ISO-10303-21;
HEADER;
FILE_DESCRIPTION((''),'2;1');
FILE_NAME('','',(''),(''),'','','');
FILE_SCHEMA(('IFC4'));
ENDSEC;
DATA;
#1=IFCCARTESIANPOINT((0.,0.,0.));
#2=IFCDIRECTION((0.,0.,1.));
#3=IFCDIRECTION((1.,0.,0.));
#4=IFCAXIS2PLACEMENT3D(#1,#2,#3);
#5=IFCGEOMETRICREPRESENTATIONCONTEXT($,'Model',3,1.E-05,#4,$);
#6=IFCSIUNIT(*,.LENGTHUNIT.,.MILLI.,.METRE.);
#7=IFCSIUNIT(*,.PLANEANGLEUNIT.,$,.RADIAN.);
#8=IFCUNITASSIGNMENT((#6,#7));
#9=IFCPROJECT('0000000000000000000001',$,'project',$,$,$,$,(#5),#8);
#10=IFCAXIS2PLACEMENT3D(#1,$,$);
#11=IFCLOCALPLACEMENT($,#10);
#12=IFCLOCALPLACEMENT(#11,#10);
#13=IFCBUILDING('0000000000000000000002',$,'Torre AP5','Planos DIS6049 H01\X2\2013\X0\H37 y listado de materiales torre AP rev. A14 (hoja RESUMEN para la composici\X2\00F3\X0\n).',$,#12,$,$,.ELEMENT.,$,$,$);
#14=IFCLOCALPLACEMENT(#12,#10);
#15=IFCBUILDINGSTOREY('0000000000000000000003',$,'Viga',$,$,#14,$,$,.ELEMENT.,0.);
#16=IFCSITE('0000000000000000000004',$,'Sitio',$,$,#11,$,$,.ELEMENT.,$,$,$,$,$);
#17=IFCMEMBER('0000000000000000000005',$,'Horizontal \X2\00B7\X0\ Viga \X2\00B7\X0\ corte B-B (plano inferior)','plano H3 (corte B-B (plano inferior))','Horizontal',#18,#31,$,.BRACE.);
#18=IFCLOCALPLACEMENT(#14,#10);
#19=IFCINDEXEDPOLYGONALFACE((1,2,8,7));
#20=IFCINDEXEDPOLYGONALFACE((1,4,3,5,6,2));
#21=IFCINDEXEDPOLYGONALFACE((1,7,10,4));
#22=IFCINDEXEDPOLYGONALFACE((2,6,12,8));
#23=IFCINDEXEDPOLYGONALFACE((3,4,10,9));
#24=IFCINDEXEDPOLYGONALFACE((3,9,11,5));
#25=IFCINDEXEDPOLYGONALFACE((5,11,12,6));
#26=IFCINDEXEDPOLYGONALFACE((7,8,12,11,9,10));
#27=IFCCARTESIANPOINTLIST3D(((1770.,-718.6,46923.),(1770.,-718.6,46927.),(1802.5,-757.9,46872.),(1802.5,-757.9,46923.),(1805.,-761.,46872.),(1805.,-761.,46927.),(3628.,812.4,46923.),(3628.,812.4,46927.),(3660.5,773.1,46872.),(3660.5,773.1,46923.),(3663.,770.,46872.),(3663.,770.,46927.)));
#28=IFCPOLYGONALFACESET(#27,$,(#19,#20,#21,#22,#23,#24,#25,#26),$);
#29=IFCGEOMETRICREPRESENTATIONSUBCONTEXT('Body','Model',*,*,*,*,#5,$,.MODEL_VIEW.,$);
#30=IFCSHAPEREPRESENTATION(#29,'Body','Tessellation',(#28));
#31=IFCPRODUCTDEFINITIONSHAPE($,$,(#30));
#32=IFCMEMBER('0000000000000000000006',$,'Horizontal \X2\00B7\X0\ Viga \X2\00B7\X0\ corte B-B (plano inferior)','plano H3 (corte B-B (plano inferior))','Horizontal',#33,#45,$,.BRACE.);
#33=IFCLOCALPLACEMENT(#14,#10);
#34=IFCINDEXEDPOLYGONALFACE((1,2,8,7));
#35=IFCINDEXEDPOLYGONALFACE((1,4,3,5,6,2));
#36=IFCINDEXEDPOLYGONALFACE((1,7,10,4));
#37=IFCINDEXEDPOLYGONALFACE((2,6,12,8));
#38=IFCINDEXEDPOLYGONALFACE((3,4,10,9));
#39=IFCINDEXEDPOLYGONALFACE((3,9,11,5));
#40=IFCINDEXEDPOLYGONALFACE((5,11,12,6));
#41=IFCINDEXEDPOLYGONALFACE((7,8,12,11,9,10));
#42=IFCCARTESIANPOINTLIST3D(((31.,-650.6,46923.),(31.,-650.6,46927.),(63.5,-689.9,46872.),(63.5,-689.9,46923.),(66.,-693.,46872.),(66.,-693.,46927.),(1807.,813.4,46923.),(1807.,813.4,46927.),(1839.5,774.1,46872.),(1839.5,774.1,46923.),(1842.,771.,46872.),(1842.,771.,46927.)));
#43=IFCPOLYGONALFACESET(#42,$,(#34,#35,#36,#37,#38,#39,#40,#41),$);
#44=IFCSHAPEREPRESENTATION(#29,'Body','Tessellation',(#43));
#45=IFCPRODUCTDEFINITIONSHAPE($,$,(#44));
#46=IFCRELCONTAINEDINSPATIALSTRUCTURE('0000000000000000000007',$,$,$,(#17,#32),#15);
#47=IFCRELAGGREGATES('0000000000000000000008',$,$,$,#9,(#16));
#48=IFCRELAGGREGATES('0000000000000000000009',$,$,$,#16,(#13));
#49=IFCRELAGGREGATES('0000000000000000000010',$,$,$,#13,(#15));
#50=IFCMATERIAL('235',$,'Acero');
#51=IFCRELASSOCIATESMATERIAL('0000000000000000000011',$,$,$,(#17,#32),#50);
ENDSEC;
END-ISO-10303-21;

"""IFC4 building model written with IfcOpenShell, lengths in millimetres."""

from ifc_helpers import new_model, si_unit, frame, frame_2d, origin, origin_with_axes, place, context, subcontext, project, spatial, l_section, extrude, material, element, save


model = new_model("IFC4")

# Units and contexts
model_context = context("Model", 3, precision=1e-05, world=origin_with_axes())
body_context = subcontext(model_context, "Body", "Model", "MODEL_VIEW")
ifc_project = project(units=[si_unit("LENGTHUNIT", "METRE", prefix="MILLI"), si_unit("PLANEANGLEUNIT", "RADIAN")], contexts=[model_context])

# Site, building, storey
site_placement = place(None, origin())
site = spatial("IfcSite", under=ifc_project, at=site_placement, Name="Sitio", CompositionType="ELEMENT")
building_placement = place(site_placement, origin())
building = spatial("IfcBuilding", under=site, at=building_placement, Name="Torre AP5", Description="Planos DIS6049 H01–H37 y listado de materiales torre AP rev. A14 (hoja RESUMEN para la composición).", CompositionType="ELEMENT")
storey_placement = place(building_placement, origin())
storey = spatial("IfcBuildingStorey", under=building, at=storey_placement, Name="Viga", CompositionType="ELEMENT", Elevation=0.0)

# Members
ifc_material = material(Name="235", Category="Acero")
member_1_placement = place(storey_placement, frame((3663.0, 770.0, 46927.0), z_axis=(-0.77175, -0.635926, 0.0), x_axis=(-0.635926, 0.77175, 0.0)))
element("IfcMember", 1, at=member_1_placement, inside=storey, material=ifc_material, Name="Horizontal · Viga · corte B-B (plano inferior)", Description="plano H3 (corte B-B (plano inferior))", ObjectType="Horizontal", PredefinedType="BRACE", context=body_context, shape_type="SweptSolid", body=[
    extrude(l_section(Depth=55.0, Width=55.0, Thickness=4.0, at=frame_2d((27.5, 27.5))), None, (0.0, 0.0, 1.0), 2407.5),
])
member_2_placement = place(storey_placement, frame((1842.0, 771.0, 46927.0), z_axis=(-0.771629, -0.636073, 0.0), x_axis=(-0.636073, 0.771629, 0.0)))
element("IfcMember", 2, at=member_2_placement, inside=storey, material=ifc_material, Name="Horizontal · Viga · corte B-B (plano inferior)", Description="plano H3 (corte B-B (plano inferior))", ObjectType="Horizontal", PredefinedType="BRACE", context=body_context, shape_type="SweptSolid", body=[
    extrude(l_section(Depth=55.0, Width=55.0, Thickness=4.0, at=frame_2d((27.5, 27.5))), None, (0.0, 0.0, 1.0), 2301.6),
])

save(model, "model.ifc")
